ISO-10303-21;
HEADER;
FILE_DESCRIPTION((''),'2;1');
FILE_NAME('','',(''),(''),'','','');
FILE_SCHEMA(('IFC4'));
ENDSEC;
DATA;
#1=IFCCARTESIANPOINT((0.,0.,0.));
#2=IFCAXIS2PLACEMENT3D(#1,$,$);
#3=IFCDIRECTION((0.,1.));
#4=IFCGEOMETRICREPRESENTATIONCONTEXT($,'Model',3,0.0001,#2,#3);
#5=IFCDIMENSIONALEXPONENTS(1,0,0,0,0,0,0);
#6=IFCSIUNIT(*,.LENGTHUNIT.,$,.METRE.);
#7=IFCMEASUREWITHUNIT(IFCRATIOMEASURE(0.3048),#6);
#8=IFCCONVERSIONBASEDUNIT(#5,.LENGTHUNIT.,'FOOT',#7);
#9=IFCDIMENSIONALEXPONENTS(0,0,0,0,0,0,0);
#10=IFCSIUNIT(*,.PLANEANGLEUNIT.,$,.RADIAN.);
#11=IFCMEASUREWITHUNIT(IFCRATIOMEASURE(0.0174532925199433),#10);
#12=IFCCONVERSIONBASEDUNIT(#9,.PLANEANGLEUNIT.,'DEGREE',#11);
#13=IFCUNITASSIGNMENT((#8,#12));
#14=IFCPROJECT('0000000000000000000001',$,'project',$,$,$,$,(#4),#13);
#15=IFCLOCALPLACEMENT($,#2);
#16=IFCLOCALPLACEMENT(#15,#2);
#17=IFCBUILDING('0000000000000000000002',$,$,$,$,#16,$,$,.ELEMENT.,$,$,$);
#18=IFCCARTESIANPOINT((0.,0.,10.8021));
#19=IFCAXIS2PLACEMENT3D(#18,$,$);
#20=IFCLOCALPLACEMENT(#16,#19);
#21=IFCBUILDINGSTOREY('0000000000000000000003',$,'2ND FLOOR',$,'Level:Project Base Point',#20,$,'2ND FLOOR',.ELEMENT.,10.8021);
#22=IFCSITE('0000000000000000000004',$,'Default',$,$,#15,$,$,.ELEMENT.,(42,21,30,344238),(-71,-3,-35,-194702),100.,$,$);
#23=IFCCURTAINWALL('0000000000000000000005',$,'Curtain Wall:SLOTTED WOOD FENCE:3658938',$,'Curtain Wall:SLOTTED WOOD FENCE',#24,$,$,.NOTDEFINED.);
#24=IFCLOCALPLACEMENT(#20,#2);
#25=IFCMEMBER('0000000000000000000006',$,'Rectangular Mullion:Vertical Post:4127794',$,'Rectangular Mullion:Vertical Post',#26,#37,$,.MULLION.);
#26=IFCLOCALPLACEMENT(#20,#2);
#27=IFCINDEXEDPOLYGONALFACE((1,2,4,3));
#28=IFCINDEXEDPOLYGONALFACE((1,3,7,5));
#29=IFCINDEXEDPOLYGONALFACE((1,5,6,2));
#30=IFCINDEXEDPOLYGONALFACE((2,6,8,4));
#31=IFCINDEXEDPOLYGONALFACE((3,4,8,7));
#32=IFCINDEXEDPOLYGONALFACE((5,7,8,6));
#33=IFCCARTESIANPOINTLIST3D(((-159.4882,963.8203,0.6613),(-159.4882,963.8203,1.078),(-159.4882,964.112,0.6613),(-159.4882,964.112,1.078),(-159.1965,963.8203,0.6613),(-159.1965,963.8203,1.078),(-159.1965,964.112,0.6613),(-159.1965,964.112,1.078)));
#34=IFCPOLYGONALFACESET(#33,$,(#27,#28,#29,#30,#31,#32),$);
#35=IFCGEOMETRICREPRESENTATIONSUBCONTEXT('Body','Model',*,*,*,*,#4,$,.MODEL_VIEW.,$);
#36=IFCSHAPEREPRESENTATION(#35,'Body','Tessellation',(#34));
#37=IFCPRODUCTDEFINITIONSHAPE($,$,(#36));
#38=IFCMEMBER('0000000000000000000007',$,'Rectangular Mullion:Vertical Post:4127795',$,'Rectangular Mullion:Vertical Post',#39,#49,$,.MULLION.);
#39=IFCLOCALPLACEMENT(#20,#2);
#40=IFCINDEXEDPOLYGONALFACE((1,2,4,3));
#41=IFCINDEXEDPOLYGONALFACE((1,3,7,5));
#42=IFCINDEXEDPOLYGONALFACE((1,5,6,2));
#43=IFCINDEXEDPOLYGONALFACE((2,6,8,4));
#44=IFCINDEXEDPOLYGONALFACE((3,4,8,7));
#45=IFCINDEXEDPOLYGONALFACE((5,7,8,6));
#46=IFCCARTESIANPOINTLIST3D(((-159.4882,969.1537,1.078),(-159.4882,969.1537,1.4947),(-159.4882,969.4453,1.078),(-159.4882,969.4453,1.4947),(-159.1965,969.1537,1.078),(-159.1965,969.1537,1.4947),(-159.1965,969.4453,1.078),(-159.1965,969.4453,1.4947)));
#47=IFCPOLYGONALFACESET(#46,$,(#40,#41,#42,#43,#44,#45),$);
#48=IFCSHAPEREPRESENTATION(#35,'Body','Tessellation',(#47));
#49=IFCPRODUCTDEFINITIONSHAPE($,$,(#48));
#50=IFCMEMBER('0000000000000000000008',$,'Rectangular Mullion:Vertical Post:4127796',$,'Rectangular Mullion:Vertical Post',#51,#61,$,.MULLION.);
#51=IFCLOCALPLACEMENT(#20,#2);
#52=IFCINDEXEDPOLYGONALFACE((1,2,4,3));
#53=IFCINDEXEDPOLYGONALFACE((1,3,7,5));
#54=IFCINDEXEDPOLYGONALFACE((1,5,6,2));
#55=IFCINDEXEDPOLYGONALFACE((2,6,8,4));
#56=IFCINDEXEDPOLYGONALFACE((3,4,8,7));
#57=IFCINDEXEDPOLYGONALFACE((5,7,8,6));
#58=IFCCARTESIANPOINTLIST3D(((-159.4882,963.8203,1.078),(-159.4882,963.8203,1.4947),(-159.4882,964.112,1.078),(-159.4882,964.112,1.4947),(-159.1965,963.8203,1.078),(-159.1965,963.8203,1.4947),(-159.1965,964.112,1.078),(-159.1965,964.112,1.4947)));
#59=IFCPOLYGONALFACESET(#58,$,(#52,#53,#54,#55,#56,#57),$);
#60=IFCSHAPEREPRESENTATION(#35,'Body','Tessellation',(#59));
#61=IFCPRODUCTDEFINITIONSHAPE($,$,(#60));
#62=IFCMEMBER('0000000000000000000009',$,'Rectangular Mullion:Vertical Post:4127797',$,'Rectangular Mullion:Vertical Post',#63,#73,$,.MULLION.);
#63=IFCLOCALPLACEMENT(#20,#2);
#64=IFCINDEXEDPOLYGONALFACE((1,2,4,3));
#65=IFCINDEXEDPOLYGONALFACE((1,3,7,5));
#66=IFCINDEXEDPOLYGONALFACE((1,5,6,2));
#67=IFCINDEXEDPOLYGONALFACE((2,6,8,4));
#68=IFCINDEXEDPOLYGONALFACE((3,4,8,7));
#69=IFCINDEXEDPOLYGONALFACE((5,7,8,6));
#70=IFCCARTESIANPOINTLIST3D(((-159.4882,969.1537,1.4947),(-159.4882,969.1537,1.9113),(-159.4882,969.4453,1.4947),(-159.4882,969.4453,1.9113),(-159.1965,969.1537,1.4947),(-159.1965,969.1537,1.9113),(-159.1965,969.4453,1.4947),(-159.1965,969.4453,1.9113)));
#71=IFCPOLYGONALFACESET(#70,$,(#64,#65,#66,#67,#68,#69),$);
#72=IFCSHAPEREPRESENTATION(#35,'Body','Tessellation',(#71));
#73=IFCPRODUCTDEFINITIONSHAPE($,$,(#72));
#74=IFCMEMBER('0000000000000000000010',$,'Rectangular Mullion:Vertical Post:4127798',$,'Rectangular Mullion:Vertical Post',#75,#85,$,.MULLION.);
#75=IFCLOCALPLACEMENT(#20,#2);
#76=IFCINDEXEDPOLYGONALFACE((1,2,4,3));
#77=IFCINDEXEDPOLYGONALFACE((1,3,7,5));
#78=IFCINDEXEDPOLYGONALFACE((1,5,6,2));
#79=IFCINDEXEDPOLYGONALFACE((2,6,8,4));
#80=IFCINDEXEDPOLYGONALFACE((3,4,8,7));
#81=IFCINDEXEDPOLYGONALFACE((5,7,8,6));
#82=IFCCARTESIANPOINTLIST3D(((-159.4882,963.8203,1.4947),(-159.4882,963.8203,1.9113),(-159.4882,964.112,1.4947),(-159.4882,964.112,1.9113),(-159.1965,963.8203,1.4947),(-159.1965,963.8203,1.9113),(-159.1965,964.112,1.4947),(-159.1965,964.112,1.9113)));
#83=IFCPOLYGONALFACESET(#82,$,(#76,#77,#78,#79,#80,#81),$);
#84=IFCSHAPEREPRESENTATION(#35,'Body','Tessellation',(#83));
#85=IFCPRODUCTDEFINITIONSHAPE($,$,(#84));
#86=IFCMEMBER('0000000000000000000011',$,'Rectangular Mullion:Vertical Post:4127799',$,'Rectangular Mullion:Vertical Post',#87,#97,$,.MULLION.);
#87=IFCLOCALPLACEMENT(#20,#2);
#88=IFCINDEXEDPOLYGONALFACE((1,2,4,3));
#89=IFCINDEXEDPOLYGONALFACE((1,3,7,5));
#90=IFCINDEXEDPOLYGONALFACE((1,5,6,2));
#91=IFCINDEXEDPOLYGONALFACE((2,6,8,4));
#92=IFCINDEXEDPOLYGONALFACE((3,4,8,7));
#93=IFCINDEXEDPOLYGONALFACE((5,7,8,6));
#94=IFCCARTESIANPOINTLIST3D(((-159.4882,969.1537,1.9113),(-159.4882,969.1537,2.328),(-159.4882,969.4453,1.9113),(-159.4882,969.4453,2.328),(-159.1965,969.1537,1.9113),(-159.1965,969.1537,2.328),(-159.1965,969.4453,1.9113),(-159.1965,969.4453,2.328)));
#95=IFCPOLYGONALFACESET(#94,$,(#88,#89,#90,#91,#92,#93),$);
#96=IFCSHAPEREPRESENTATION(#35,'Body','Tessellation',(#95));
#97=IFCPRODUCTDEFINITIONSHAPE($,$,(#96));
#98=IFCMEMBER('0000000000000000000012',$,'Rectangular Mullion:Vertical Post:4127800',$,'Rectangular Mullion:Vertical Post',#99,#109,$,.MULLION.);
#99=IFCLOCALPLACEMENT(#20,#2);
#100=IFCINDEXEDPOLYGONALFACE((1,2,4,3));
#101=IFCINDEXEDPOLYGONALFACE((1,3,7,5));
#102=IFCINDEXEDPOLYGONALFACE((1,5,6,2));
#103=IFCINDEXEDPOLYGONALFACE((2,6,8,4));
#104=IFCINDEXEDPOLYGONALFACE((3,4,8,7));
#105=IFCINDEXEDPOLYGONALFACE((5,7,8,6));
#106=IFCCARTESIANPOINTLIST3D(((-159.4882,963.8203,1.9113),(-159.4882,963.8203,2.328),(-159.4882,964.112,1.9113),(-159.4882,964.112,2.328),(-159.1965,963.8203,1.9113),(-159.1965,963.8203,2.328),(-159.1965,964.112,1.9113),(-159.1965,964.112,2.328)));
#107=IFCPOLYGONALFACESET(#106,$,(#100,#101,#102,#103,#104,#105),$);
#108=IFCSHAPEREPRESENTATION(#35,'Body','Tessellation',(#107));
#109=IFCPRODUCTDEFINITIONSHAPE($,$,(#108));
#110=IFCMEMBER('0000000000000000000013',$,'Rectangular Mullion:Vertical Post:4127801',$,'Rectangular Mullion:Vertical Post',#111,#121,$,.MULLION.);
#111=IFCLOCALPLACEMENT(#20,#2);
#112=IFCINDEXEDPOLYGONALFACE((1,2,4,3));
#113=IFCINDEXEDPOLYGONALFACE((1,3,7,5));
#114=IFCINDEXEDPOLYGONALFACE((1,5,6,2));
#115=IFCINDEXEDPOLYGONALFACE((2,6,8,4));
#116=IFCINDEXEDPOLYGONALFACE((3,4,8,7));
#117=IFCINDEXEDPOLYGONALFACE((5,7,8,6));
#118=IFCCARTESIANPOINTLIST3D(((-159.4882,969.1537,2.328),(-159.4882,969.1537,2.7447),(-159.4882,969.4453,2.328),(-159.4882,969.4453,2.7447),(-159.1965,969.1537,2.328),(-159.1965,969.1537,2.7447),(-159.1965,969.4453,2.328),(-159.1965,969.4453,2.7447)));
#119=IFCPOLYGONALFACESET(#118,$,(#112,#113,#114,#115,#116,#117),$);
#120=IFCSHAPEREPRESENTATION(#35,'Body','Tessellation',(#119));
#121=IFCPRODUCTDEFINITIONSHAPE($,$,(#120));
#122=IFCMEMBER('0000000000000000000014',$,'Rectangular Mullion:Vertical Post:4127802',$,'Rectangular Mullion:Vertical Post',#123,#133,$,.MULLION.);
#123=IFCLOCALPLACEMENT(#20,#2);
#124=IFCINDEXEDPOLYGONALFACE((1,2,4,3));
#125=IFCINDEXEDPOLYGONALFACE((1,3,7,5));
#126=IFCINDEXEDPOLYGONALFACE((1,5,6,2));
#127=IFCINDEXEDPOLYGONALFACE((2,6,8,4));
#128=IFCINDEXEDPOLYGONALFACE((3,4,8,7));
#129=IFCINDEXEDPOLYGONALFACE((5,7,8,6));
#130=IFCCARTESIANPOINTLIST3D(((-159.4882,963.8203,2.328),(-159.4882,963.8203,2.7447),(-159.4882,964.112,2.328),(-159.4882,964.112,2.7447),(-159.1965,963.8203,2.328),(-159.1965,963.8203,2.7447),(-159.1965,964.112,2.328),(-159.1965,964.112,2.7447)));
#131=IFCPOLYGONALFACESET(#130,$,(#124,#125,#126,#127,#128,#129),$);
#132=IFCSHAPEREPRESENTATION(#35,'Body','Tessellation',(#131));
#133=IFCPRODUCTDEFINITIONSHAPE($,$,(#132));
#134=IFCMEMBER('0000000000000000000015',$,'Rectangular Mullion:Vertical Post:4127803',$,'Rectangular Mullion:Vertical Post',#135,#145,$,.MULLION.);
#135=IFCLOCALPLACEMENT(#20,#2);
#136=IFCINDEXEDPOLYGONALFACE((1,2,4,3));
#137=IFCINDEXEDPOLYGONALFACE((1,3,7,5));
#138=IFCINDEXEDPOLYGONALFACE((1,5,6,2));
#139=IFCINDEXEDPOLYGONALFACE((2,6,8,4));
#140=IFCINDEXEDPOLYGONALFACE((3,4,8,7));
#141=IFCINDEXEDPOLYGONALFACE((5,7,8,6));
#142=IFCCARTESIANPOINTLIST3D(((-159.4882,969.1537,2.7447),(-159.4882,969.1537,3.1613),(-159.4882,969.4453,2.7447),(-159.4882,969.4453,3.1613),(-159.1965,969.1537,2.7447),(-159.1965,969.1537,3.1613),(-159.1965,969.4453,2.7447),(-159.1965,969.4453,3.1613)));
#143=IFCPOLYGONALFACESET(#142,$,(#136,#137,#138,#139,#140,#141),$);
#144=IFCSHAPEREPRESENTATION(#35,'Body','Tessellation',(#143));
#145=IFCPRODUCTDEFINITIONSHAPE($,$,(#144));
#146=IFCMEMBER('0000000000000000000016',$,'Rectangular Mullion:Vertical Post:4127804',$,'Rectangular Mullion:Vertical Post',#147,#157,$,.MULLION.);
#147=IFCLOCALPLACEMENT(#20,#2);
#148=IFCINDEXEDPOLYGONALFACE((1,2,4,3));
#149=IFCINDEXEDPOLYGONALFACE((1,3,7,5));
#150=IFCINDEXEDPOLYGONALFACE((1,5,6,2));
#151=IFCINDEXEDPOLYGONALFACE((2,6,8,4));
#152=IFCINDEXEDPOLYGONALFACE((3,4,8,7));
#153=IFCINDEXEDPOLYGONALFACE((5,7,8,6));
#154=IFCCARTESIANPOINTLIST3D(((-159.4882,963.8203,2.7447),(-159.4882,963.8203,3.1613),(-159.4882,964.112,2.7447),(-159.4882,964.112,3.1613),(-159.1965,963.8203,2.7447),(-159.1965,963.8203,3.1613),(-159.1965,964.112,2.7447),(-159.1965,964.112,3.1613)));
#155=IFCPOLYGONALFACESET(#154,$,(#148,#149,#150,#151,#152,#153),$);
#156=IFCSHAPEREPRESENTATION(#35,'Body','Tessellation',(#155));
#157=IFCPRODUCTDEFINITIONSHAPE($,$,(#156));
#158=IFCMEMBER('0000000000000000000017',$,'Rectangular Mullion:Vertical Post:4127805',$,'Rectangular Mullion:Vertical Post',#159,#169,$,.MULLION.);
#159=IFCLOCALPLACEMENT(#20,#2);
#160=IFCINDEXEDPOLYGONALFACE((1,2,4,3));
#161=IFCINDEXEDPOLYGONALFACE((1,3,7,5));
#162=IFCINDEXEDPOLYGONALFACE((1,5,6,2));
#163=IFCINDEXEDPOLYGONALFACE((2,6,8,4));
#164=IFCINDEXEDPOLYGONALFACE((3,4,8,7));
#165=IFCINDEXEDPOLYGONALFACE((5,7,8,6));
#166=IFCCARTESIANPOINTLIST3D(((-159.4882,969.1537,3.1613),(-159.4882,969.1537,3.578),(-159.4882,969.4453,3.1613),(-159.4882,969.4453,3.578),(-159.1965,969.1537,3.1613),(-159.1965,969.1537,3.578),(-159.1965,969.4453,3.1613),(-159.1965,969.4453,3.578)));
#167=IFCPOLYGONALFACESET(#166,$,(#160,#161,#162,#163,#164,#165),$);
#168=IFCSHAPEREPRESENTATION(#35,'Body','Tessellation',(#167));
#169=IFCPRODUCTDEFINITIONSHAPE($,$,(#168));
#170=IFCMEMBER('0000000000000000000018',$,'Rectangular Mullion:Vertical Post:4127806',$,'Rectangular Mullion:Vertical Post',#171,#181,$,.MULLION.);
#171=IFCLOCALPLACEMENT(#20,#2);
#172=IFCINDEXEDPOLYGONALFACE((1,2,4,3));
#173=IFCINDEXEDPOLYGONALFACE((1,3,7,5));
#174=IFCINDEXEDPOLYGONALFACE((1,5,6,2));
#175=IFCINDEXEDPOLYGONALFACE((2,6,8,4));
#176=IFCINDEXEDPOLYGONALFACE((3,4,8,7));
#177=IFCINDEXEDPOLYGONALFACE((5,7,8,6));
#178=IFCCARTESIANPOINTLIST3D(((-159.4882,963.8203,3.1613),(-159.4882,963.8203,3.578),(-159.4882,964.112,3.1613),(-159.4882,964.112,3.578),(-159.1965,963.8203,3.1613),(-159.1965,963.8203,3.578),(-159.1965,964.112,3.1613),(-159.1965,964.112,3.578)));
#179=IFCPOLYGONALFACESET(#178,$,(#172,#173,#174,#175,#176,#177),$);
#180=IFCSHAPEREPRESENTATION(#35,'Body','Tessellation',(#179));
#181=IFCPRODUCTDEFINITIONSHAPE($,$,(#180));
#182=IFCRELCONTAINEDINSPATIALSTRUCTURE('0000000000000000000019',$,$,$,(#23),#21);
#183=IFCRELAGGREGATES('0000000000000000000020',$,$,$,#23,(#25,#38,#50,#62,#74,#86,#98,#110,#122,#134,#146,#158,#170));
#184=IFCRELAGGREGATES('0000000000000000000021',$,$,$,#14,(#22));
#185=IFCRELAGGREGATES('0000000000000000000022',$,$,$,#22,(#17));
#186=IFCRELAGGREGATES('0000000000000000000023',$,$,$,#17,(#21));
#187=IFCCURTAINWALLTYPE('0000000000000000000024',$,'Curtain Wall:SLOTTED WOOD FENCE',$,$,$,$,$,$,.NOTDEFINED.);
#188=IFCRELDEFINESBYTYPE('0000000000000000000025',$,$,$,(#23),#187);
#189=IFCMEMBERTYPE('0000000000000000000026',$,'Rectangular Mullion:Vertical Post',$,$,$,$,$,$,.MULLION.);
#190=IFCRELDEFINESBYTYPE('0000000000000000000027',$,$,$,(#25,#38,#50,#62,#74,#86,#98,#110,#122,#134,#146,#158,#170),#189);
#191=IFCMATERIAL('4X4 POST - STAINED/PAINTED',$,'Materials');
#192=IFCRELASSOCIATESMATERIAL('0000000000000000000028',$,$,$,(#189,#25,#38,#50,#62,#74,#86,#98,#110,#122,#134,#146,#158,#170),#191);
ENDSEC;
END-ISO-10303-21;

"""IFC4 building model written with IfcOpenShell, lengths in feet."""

from ifc_helpers import new_model, entity, si_unit, converted_unit, direction, frame, origin, origin_2d_with_axis, place, context, subcontext, project, spatial, rectangle, extrude, source, transform, mapped, material, material_profile, profile_set, profile_usage, type_object, type_shapes, element, aggregate, save


model = new_model("IFC4")

# Units and contexts
model_context = context("Model", 3, precision=0.0001, world=origin(), true_north=direction((0.0, 1.0)))
body_context = subcontext(model_context, "Body", "Model", "MODEL_VIEW")
ifc_project = project(units=[converted_unit("LENGTHUNIT", "FOOT", entity("IfcRatioMeasure", 0.3048), si_unit("LENGTHUNIT", "METRE"), dimensions=[1, 0, 0, 0, 0, 0, 0]), converted_unit("PLANEANGLEUNIT", "DEGREE", entity("IfcRatioMeasure", 0.0174532925199433), si_unit("PLANEANGLEUNIT", "RADIAN"), dimensions=[0, 0, 0, 0, 0, 0, 0])], contexts=[model_context])

# Site, building, storey
site_placement = place(None, origin())
site = spatial("IfcSite", under=ifc_project, at=site_placement, Name="Default", CompositionType="ELEMENT", RefLatitude=(42, 21, 30, 344238), RefLongitude=(-71, -3, -35, -194702), RefElevation=100.0)
building_placement = place(site_placement, origin())
building = spatial("IfcBuilding", under=site, at=building_placement, CompositionType="ELEMENT")
storey_placement = place(building_placement, frame((0.0, 0.0, 10.8021)))
storey = spatial("IfcBuildingStorey", under=building, at=storey_placement, Name="2ND FLOOR", ObjectType="Level:Project Base Point", LongName="2ND FLOOR", CompositionType="ELEMENT", Elevation=10.8021)

# Curtain wall, members
curtain_wall_type = type_object("IfcCurtainWallType", Name="Curtain Wall:SLOTTED WOOD FENCE", PredefinedType="NOTDEFINED")
curtain_wall_placement = place(storey_placement, frame((0.0, 0.0, -10.8021)))
curtain_wall = element("IfcCurtainWall", 1, at=curtain_wall_placement, inside=storey, type_object=curtain_wall_type, Name="Curtain Wall:SLOTTED WOOD FENCE:3658938", ObjectType="Curtain Wall:SLOTTED WOOD FENCE", PredefinedType="NOTDEFINED")
ifc_material = material(Name="4X4 POST - STAINED/PAINTED", Category="Materials")
ifc_material_profile = material_profile(ifc_material, rectangle(XDim=0.2917, YDim=0.2917, at=origin_2d_with_axis()), Name="Vertical Post")
ifc_profile_set = profile_set([ifc_material_profile], Name="Vertical Post")
member_type_1 = type_object("IfcMemberType", Name="Rectangular Mullion:Vertical Post", PredefinedType="MULLION", material=ifc_profile_set)
shared_shape_1 = source(origin(), body_context, "Body", "SweptSolid", [
    extrude(rectangle(XDim=0.2917, YDim=0.2917, at=origin_2d_with_axis()), frame((0.0, -0.2083, -0.4167), z_axis=(0.0, 0.0, 1.0), x_axis=(0.0, -1.0, 0.0)), (0.0, 0.0, 1.0), 0.4167),
])
type_shapes(member_type_1, [shared_shape_1])
ifc_profile_usage_1 = profile_usage(ifc_profile_set)
member_1_placement = place(storey_placement, frame((-159.5507, 963.9662, 0.6613), z_axis=(0.0, 0.0, -1.0), x_axis=(0.0, -1.0, 0.0)))
member_1 = element("IfcMember", 2, at=member_1_placement, type_object=member_type_1, material=ifc_profile_usage_1, Name="Rectangular Mullion:Vertical Post:4127794", ObjectType="Rectangular Mullion:Vertical Post", PredefinedType="MULLION", context=body_context, shape_type="MappedRepresentation", body=[
    mapped(shared_shape_1, transform((0.0, 0.0, 0.0), scale=1.0)),
])
ifc_profile_usage_2 = profile_usage(ifc_profile_set)
member_2_placement = place(storey_placement, frame((-159.5507, 969.2995, 1.078), z_axis=(0.0, 0.0, -1.0), x_axis=(0.0, -1.0, 0.0)))
member_2 = element("IfcMember", 3, at=member_2_placement, type_object=member_type_1, material=ifc_profile_usage_2, Name="Rectangular Mullion:Vertical Post:4127795", ObjectType="Rectangular Mullion:Vertical Post", PredefinedType="MULLION", context=body_context, shape_type="MappedRepresentation", body=[
    mapped(shared_shape_1, transform((0.0, 0.0, 0.0), scale=1.0)),
])
ifc_profile_usage_3 = profile_usage(ifc_profile_set)
member_3_placement = place(storey_placement, frame((-159.5507, 963.9662, 1.078), z_axis=(0.0, 0.0, -1.0), x_axis=(0.0, -1.0, 0.0)))
member_3 = element("IfcMember", 4, at=member_3_placement, type_object=member_type_1, material=ifc_profile_usage_3, Name="Rectangular Mullion:Vertical Post:4127796", ObjectType="Rectangular Mullion:Vertical Post", PredefinedType="MULLION", context=body_context, shape_type="MappedRepresentation", body=[
    mapped(shared_shape_1, transform((0.0, 0.0, 0.0), scale=1.0)),
])
ifc_profile_usage_4 = profile_usage(ifc_profile_set)
member_4_placement = place(storey_placement, frame((-159.5507, 969.2995, 1.4947), z_axis=(0.0, 0.0, -1.0), x_axis=(0.0, -1.0, 0.0)))
member_4 = element("IfcMember", 5, at=member_4_placement, type_object=member_type_1, material=ifc_profile_usage_4, Name="Rectangular Mullion:Vertical Post:4127797", ObjectType="Rectangular Mullion:Vertical Post", PredefinedType="MULLION", context=body_context, shape_type="MappedRepresentation", body=[
    mapped(shared_shape_1, transform((0.0, 0.0, 0.0), scale=1.0)),
])
ifc_profile_usage_5 = profile_usage(ifc_profile_set)
member_5_placement = place(storey_placement, frame((-159.5507, 963.9662, 1.4947), z_axis=(0.0, 0.0, -1.0), x_axis=(0.0, -1.0, 0.0)))
member_5 = element("IfcMember", 6, at=member_5_placement, type_object=member_type_1, material=ifc_profile_usage_5, Name="Rectangular Mullion:Vertical Post:4127798", ObjectType="Rectangular Mullion:Vertical Post", PredefinedType="MULLION", context=body_context, shape_type="MappedRepresentation", body=[
    mapped(shared_shape_1, transform((0.0, 0.0, 0.0), scale=1.0)),
])
ifc_profile_usage_6 = profile_usage(ifc_profile_set)
member_6_placement = place(storey_placement, frame((-159.5507, 969.2995, 1.9113), z_axis=(0.0, 0.0, -1.0), x_axis=(0.0, -1.0, 0.0)))
member_6 = element("IfcMember", 7, at=member_6_placement, type_object=member_type_1, material=ifc_profile_usage_6, Name="Rectangular Mullion:Vertical Post:4127799", ObjectType="Rectangular Mullion:Vertical Post", PredefinedType="MULLION", context=body_context, shape_type="MappedRepresentation", body=[
    mapped(shared_shape_1, transform((0.0, 0.0, 0.0), scale=1.0)),
])
ifc_profile_usage_7 = profile_usage(ifc_profile_set)
member_7_placement = place(storey_placement, frame((-159.5507, 963.9662, 1.9113), z_axis=(0.0, 0.0, -1.0), x_axis=(0.0, -1.0, 0.0)))
member_7 = element("IfcMember", 8, at=member_7_placement, type_object=member_type_1, material=ifc_profile_usage_7, Name="Rectangular Mullion:Vertical Post:4127800", ObjectType="Rectangular Mullion:Vertical Post", PredefinedType="MULLION", context=body_context, shape_type="MappedRepresentation", body=[
    mapped(shared_shape_1, transform((0.0, 0.0, 0.0), scale=1.0)),
])
ifc_profile_usage_8 = profile_usage(ifc_profile_set)
member_8_placement = place(storey_placement, frame((-159.5507, 969.2995, 2.328), z_axis=(0.0, 0.0, -1.0), x_axis=(0.0, -1.0, 0.0)))
member_8 = element("IfcMember", 9, at=member_8_placement, type_object=member_type_1, material=ifc_profile_usage_8, Name="Rectangular Mullion:Vertical Post:4127801", ObjectType="Rectangular Mullion:Vertical Post", PredefinedType="MULLION", context=body_context, shape_type="MappedRepresentation", body=[
    mapped(shared_shape_1, transform((0.0, 0.0, 0.0), scale=1.0)),
])
ifc_profile_usage_9 = profile_usage(ifc_profile_set)
member_9_placement = place(storey_placement, frame((-159.5507, 963.9662, 2.328), z_axis=(0.0, 0.0, -1.0), x_axis=(0.0, -1.0, 0.0)))
member_9 = element("IfcMember", 10, at=member_9_placement, type_object=member_type_1, material=ifc_profile_usage_9, Name="Rectangular Mullion:Vertical Post:4127802", ObjectType="Rectangular Mullion:Vertical Post", PredefinedType="MULLION", context=body_context, shape_type="MappedRepresentation", body=[
    mapped(shared_shape_1, transform((0.0, 0.0, 0.0), scale=1.0)),
])
ifc_profile_usage_10 = profile_usage(ifc_profile_set)
member_10_placement = place(storey_placement, frame((-159.5507, 969.2995, 2.7447), z_axis=(0.0, 0.0, -1.0), x_axis=(0.0, -1.0, 0.0)))
member_10 = element("IfcMember", 11, at=member_10_placement, type_object=member_type_1, material=ifc_profile_usage_10, Name="Rectangular Mullion:Vertical Post:4127803", ObjectType="Rectangular Mullion:Vertical Post", PredefinedType="MULLION", context=body_context, shape_type="MappedRepresentation", body=[
    mapped(shared_shape_1, transform((0.0, 0.0, 0.0), scale=1.0)),
])
ifc_profile_usage_11 = profile_usage(ifc_profile_set)
member_11_placement = place(storey_placement, frame((-159.5507, 963.9662, 2.7447), z_axis=(0.0, 0.0, -1.0), x_axis=(0.0, -1.0, 0.0)))
member_11 = element("IfcMember", 12, at=member_11_placement, type_object=member_type_1, material=ifc_profile_usage_11, Name="Rectangular Mullion:Vertical Post:4127804", ObjectType="Rectangular Mullion:Vertical Post", PredefinedType="MULLION", context=body_context, shape_type="MappedRepresentation", body=[
    mapped(shared_shape_1, transform((0.0, 0.0, 0.0), scale=1.0)),
])
ifc_profile_usage_12 = profile_usage(ifc_profile_set)
member_12_placement = place(storey_placement, frame((-159.5507, 969.2995, 3.1613), z_axis=(0.0, 0.0, -1.0), x_axis=(0.0, -1.0, 0.0)))
member_12 = element("IfcMember", 13, at=member_12_placement, type_object=member_type_1, material=ifc_profile_usage_12, Name="Rectangular Mullion:Vertical Post:4127805", ObjectType="Rectangular Mullion:Vertical Post", PredefinedType="MULLION", context=body_context, shape_type="MappedRepresentation", body=[
    mapped(shared_shape_1, transform((0.0, 0.0, 0.0), scale=1.0)),
])
ifc_profile_usage_13 = profile_usage(ifc_profile_set)
member_13_placement = place(storey_placement, frame((-159.5507, 963.9662, 3.1613), z_axis=(0.0, 0.0, -1.0), x_axis=(0.0, -1.0, 0.0)))
member_13 = element("IfcMember", 14, at=member_13_placement, type_object=member_type_1, material=ifc_profile_usage_13, Name="Rectangular Mullion:Vertical Post:4127806", ObjectType="Rectangular Mullion:Vertical Post", PredefinedType="MULLION", context=body_context, shape_type="MappedRepresentation", body=[
    mapped(shared_shape_1, transform((0.0, 0.0, 0.0), scale=1.0)),
])
aggregate(curtain_wall, [member_1, member_2, member_3, member_4, member_5, member_6, member_7, member_8, member_9, member_10, member_11, member_12, member_13])

save(model, "model.ifc")
